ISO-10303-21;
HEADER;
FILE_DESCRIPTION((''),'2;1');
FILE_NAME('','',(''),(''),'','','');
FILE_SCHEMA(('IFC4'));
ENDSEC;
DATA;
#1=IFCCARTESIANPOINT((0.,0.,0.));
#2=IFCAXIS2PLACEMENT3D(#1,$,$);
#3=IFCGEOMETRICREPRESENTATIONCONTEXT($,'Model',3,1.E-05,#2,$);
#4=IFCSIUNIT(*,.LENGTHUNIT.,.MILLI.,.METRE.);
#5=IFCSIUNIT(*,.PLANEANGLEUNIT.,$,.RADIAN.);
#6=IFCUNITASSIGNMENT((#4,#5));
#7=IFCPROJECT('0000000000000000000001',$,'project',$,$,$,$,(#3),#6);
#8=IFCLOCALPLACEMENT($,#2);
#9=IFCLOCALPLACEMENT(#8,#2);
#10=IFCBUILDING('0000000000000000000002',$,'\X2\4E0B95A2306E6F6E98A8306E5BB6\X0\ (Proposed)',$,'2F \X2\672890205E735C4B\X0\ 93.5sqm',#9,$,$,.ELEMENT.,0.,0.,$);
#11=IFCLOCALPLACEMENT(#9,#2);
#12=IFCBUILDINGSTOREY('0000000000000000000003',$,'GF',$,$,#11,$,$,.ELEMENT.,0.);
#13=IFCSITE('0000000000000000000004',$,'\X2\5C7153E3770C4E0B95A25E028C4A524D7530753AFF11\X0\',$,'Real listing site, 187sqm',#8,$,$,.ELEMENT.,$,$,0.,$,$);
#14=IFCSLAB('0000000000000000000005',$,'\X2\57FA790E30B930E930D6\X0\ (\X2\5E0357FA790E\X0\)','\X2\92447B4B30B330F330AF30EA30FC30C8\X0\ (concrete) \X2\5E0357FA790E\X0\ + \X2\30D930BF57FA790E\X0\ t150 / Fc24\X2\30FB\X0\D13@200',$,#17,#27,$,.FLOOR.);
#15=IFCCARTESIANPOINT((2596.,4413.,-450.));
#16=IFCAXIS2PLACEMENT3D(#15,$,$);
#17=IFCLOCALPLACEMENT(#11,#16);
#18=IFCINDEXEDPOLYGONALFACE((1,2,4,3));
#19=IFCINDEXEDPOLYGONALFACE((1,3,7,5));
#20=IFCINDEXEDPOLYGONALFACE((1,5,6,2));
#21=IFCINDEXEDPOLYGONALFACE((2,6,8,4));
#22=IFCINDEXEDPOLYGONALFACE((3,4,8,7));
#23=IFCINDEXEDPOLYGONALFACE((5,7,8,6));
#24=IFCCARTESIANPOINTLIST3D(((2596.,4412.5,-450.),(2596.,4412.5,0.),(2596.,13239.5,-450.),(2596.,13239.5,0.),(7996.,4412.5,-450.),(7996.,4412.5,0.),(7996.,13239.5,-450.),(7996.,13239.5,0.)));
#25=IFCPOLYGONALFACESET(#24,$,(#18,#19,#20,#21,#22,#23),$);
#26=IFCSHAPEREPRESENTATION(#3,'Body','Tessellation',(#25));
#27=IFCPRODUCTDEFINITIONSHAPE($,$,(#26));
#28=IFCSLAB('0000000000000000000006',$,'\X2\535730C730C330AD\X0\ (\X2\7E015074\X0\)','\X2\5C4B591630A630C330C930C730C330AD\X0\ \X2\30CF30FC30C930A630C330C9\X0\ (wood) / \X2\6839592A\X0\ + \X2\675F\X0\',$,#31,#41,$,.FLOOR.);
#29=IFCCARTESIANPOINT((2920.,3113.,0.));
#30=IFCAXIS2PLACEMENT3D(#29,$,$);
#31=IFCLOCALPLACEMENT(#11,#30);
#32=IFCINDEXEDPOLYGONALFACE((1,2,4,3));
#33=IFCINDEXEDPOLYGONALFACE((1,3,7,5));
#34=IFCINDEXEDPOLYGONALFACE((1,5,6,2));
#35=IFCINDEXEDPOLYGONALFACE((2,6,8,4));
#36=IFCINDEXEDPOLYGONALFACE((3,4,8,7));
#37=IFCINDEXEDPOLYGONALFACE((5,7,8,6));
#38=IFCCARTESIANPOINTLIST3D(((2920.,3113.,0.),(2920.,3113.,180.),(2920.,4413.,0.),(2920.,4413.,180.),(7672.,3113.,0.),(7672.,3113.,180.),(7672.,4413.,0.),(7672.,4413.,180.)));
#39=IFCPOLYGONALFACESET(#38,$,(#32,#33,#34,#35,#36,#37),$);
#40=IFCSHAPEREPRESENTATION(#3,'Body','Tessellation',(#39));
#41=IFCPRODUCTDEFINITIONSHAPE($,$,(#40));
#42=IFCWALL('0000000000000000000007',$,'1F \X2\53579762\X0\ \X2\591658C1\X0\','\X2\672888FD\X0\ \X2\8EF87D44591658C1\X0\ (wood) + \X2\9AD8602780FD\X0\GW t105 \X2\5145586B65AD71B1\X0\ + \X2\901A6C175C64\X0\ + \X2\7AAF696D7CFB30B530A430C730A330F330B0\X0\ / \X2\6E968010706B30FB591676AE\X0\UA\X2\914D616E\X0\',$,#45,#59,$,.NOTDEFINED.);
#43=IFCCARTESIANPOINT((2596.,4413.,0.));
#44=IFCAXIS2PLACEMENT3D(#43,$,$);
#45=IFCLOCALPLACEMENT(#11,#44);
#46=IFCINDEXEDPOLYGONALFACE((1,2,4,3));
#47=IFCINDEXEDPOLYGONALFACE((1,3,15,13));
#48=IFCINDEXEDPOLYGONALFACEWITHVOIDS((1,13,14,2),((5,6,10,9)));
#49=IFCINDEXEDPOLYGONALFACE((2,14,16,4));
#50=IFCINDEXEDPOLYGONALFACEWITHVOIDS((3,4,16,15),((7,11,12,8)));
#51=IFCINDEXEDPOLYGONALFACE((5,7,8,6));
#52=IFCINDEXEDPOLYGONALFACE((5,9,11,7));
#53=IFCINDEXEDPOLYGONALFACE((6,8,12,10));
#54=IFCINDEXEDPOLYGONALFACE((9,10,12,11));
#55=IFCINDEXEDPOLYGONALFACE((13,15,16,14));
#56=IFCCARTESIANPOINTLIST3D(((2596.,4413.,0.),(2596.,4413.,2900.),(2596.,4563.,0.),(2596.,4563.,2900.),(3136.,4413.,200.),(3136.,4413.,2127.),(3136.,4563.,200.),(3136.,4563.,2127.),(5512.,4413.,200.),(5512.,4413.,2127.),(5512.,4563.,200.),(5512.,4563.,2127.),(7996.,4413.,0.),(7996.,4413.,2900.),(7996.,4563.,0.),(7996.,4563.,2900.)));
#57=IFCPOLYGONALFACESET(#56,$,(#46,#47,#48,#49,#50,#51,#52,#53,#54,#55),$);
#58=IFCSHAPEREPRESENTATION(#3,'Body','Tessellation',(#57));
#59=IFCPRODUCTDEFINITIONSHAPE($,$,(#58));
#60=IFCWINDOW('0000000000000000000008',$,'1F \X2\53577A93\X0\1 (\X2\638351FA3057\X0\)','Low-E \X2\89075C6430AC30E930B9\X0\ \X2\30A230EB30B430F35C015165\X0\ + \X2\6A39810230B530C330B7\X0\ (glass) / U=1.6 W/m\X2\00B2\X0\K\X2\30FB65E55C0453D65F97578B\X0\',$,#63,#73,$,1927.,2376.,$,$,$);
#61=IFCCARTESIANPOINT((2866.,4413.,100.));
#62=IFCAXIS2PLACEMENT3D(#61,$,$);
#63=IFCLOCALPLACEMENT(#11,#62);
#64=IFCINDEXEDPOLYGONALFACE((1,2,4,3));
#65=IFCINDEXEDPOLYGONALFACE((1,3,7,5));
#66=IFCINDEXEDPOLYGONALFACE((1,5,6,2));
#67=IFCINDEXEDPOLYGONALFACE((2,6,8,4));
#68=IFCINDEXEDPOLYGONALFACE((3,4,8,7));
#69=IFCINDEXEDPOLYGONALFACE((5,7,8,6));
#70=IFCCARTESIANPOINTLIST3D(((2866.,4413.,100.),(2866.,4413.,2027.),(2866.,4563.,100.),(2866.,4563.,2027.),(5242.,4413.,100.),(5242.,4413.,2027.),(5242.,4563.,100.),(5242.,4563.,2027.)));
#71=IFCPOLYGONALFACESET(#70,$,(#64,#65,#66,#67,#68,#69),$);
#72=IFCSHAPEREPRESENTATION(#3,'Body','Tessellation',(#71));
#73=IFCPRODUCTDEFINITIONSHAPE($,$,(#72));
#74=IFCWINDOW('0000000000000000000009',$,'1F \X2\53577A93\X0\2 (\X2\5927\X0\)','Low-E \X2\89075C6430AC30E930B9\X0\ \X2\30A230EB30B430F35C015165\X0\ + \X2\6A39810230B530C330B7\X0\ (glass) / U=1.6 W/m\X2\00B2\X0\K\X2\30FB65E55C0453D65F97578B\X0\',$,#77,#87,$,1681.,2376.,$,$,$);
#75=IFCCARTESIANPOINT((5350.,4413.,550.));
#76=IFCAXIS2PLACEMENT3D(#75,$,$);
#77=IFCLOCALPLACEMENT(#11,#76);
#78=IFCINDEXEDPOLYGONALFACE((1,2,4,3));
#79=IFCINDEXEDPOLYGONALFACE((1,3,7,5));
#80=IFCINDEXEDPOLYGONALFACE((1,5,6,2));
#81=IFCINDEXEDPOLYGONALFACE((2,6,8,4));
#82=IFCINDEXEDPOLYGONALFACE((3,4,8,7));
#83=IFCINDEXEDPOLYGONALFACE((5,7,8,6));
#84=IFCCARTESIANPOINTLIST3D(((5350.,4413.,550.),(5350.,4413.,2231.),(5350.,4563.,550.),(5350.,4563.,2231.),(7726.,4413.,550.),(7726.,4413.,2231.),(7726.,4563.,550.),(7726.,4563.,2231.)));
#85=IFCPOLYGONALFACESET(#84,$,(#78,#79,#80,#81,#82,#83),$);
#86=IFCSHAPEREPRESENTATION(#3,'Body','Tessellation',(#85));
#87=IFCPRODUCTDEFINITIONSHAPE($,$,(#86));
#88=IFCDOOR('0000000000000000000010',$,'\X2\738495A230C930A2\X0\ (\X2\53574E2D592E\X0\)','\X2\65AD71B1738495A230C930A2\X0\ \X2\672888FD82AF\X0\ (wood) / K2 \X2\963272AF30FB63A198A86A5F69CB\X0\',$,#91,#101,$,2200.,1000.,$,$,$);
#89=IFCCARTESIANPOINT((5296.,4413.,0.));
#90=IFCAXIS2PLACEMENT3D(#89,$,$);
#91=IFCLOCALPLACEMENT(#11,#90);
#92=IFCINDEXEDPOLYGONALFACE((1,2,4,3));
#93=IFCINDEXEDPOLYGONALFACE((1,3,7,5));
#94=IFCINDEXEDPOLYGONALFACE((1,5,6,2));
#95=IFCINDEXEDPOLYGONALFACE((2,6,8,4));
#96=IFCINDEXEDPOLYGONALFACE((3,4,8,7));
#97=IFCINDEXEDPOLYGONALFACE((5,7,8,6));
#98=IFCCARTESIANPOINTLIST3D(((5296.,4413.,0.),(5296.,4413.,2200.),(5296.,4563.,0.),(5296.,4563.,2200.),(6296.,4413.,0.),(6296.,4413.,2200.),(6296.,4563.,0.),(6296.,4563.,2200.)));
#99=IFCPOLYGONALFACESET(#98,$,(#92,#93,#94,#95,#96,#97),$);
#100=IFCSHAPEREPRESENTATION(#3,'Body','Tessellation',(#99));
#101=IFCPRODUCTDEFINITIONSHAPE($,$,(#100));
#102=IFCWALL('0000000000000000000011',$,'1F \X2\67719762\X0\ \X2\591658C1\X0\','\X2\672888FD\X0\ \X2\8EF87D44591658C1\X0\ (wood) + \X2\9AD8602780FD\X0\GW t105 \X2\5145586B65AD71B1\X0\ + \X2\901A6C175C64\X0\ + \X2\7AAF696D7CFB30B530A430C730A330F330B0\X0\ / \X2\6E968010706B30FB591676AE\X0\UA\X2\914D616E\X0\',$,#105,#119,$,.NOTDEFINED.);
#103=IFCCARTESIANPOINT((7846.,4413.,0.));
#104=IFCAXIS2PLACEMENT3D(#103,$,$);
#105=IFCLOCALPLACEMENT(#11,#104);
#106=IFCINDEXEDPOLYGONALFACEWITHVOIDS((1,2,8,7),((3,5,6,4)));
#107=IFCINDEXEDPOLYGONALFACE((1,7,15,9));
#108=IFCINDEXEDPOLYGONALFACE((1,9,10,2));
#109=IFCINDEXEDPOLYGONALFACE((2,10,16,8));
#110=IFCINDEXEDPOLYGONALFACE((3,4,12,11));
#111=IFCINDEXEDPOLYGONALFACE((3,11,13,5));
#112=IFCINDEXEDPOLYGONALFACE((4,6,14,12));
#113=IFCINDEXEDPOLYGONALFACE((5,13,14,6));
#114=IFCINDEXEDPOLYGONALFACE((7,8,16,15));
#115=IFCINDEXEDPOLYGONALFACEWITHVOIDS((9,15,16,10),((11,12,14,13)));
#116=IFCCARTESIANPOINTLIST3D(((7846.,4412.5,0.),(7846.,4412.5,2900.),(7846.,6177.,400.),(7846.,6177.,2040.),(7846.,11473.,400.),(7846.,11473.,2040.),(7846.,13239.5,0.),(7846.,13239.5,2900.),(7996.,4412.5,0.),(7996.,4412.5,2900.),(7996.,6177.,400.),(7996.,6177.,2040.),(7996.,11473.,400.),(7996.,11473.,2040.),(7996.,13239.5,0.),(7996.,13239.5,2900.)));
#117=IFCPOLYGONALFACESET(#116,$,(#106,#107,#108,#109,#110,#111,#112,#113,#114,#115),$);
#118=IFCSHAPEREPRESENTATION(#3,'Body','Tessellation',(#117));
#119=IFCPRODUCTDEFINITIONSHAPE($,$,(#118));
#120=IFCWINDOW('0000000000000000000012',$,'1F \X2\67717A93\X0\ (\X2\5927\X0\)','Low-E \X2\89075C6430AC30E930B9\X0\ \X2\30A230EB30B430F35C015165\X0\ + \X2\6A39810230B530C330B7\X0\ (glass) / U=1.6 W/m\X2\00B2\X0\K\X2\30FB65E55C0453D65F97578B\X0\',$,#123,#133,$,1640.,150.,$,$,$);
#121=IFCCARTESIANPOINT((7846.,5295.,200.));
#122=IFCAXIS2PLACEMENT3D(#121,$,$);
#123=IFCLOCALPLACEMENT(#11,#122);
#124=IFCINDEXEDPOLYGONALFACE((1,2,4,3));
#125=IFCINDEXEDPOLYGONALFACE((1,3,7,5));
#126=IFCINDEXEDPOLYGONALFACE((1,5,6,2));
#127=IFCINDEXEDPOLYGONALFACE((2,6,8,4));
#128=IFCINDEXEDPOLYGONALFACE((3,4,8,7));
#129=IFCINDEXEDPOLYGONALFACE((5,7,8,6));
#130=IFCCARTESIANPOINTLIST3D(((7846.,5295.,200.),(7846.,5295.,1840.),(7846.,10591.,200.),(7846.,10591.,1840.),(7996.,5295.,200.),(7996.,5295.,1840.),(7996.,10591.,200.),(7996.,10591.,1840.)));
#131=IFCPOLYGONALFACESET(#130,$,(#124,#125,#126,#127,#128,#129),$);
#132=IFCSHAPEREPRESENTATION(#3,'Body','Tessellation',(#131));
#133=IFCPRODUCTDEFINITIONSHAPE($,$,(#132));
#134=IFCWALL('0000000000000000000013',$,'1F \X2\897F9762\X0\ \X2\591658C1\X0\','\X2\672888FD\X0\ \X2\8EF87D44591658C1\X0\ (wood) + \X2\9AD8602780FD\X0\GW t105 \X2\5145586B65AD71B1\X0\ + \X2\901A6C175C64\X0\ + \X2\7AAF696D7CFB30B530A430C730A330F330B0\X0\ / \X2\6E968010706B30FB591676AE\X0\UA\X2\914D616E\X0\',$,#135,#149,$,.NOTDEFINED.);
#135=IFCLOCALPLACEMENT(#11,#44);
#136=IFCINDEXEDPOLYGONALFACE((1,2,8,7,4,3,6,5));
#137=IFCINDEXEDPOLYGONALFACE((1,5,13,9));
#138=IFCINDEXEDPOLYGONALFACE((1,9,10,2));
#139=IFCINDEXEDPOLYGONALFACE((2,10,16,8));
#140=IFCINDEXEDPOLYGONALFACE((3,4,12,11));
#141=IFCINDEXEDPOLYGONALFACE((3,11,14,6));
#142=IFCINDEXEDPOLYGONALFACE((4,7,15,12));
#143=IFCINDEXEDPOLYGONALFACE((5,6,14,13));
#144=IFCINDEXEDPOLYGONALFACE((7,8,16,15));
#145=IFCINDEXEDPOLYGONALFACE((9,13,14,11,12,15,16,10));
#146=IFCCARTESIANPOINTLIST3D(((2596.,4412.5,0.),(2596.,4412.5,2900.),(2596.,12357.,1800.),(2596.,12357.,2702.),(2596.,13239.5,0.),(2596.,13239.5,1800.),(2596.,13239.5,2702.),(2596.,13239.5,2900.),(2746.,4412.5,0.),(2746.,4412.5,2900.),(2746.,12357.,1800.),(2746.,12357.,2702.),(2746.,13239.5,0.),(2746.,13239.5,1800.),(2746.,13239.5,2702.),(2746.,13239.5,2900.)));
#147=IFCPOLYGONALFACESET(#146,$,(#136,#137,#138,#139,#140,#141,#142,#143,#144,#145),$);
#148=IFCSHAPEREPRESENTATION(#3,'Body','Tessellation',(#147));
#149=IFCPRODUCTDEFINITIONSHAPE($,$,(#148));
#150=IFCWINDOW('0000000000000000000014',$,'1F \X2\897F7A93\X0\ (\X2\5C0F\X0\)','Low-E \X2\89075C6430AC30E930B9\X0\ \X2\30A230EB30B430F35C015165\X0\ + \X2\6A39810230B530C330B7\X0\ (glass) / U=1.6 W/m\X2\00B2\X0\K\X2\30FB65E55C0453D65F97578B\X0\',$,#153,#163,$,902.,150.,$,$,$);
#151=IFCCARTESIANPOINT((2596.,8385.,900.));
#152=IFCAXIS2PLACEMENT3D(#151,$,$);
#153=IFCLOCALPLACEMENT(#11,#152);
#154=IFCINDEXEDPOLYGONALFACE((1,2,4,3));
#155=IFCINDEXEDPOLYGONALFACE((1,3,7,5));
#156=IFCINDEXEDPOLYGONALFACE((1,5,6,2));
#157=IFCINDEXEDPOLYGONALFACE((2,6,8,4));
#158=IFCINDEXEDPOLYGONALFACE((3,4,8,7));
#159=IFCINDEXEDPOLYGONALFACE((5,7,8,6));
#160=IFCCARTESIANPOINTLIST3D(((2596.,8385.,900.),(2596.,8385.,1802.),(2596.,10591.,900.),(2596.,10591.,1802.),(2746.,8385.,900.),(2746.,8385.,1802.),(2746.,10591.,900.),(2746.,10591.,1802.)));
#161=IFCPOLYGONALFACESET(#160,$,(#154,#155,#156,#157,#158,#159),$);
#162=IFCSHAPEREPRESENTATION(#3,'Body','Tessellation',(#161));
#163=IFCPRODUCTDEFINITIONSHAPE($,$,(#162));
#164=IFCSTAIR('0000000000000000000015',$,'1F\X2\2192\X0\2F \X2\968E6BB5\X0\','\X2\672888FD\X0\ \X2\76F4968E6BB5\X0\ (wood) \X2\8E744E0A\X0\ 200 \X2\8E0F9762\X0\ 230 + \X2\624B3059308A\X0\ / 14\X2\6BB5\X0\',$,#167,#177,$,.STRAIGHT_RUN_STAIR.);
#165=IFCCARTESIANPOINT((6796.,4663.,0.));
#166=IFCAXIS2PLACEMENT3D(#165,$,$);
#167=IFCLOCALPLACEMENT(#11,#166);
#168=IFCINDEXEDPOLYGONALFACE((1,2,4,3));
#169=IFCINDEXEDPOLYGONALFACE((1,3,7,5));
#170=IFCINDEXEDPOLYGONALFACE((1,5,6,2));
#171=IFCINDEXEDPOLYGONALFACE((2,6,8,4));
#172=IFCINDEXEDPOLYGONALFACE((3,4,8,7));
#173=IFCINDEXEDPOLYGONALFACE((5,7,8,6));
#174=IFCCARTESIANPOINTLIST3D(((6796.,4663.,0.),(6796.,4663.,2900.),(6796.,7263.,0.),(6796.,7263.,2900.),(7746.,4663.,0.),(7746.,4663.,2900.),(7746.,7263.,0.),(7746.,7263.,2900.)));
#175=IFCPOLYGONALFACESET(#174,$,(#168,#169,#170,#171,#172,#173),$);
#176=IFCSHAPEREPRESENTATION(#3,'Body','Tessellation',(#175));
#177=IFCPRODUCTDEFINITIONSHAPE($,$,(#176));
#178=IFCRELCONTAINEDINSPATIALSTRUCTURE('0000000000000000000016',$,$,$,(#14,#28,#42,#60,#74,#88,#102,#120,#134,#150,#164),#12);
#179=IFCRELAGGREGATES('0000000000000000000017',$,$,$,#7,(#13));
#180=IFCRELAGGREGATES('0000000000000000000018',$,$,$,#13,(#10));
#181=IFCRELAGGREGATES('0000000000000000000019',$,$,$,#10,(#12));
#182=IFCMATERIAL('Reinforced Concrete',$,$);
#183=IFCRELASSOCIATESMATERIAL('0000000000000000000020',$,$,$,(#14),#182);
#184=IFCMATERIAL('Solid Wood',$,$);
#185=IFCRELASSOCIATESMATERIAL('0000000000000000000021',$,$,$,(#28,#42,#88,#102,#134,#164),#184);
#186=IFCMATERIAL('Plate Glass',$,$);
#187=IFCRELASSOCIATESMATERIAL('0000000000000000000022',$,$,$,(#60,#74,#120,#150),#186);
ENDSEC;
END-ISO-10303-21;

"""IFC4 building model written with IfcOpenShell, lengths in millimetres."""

from ifc_helpers import new_model, si_unit, frame, frame_2d, origin, place, context, project, spatial, rectangle, extrude, material, element, fill, save


model = new_model("IFC4")

# Units and contexts
model_context = context("Model", 3, precision=1e-05, world=origin())
ifc_project = project(units=[si_unit("LENGTHUNIT", "METRE", prefix="MILLI"), si_unit("PLANEANGLEUNIT", "RADIAN")], contexts=[model_context])

# Site, building, storey
site_placement = place(None, origin())
site = spatial("IfcSite", under=ifc_project, at=site_placement, Name="山口県下関市豊前田町１", ObjectType="Real listing site, 187sqm", CompositionType="ELEMENT", RefElevation=0.0)
building_placement = place(site_placement, origin())
building = spatial("IfcBuilding", under=site, at=building_placement, Name="下関の潮風の家 (Proposed)", ObjectType="2F 木造平屋 93.5sqm", CompositionType="ELEMENT", ElevationOfRefHeight=0.0, ElevationOfTerrain=0.0)
storey_placement = place(building_placement, origin())
storey = spatial("IfcBuildingStorey", under=building, at=storey_placement, Name="GF", CompositionType="ELEMENT", Elevation=0.0)

# Slabs
ifc_material_1 = material(Name="Reinforced Concrete")
slab_1_placement = place(storey_placement, frame((2596.0, 4413.0, -450.0)))
element("IfcSlab", 1, at=slab_1_placement, inside=storey, material=ifc_material_1, Name="基礎スラブ (布基礎)", Description="鉄筋コンクリート (concrete) 布基礎 + ベタ基礎 t150 / Fc24・D13@200", PredefinedType="FLOOR", context=model_context, shape_type="SweptSolid", body=[
    extrude(rectangle(XDim=5400.0, YDim=8827.0, at=frame_2d((2700.0, 4413.0))), frame((2596.0, 4413.0, -450.0)), (0.0, 0.0, 1.0), 450.0),
])
ifc_material_2 = material(Name="Solid Wood")
slab_2_placement = place(storey_placement, frame((2920.0, 3113.0, 0.0)))
element("IfcSlab", 2, at=slab_2_placement, inside=storey, material=ifc_material_2, Name="南デッキ (縁側)", Description="屋外ウッドデッキ ハードウッド (wood) / 根太 + 束", PredefinedType="FLOOR", context=model_context, shape_type="SweptSolid", body=[
    extrude(rectangle(XDim=4752.0, YDim=1300.0, at=frame_2d((2376.0, 650.0))), frame((2920.0, 3113.0, 0.0)), (0.0, 0.0, 1.0), 180.0),
])

# Wall, openings, windows, door
wall_1_placement = place(storey_placement, frame((2596.0, 4413.0, 0.0)))
wall_1 = element("IfcWall", 3, at=wall_1_placement, inside=storey, material=ifc_material_2, Name="1F 南面 外壁", Description="木製 軸組外壁 (wood) + 高性能GW t105 充填断熱 + 通気層 + 窯業系サイディング / 準耐火・外皮UA配慮", PredefinedType="NOTDEFINED", context=model_context, shape_type="SweptSolid", body=[
    extrude(rectangle(XDim=5400.0, YDim=150.0, at=frame_2d((2700.0, 75.0))), frame((2596.0, 4413.0, 0.0)), (0.0, 0.0, 1.0), 2900.0),
])
opening_1_placement = place(storey_placement, frame((2866.0, 4413.0, 100.0)))
opening_1 = element("IfcOpeningElement", 4, at=opening_1_placement, cuts=wall_1, PredefinedType="NOTDEFINED", context=model_context, shape_type="SweptSolid", body=[
    extrude(rectangle(XDim=2376.0, YDim=150.0, at=frame_2d((1188.0, 75.0))), frame((2866.0, 4413.0, 100.0)), (0.0, 0.0, 1.0), 1927.0),
])
opening_2_placement = place(storey_placement, frame((5350.0, 4413.0, 550.0)))
opening_2 = element("IfcOpeningElement", 5, at=opening_2_placement, cuts=wall_1, PredefinedType="NOTDEFINED", context=model_context, shape_type="SweptSolid", body=[
    extrude(rectangle(XDim=2376.0, YDim=150.0, at=frame_2d((1188.0, 75.0))), frame((5350.0, 4413.0, 550.0)), (0.0, 0.0, 1.0), 1681.0),
])
opening_3_placement = place(storey_placement, frame((5296.0, 4413.0, 0.0)))
opening_3 = element("IfcOpeningElement", 6, at=opening_3_placement, cuts=wall_1, PredefinedType="NOTDEFINED", context=model_context, shape_type="SweptSolid", body=[
    extrude(rectangle(XDim=1000.0, YDim=150.0, at=frame_2d((500.0, 75.0))), frame((5296.0, 4413.0, 0.0)), (0.0, 0.0, 1.0), 2200.0),
])
ifc_material_3 = material(Name="Plate Glass")
window_1_placement = place(storey_placement, frame((2866.0, 4413.0, 100.0)))
window_1 = element("IfcWindow", 7, at=window_1_placement, inside=storey, material=ifc_material_3, Name="1F 南窓1 (掃出し)", Description="Low-E 複層ガラス アルゴン封入 + 樹脂サッシ (glass) / U=1.6 W/m²K・日射取得型", OverallHeight=1927.0, OverallWidth=2376.0, context=model_context, shape_type="SweptSolid", body=[
    extrude(rectangle(XDim=2376.0, YDim=150.0, at=frame_2d((1188.0, 75.0))), frame((2866.0, 4413.0, 100.0)), (0.0, 0.0, 1.0), 1927.0),
])
fill(opening_1, window_1)
window_2_placement = place(storey_placement, frame((5350.0, 4413.0, 550.0)))
window_2 = element("IfcWindow", 8, at=window_2_placement, inside=storey, material=ifc_material_3, Name="1F 南窓2 (大)", Description="Low-E 複層ガラス アルゴン封入 + 樹脂サッシ (glass) / U=1.6 W/m²K・日射取得型", OverallHeight=1681.0, OverallWidth=2376.0, context=model_context, shape_type="SweptSolid", body=[
    extrude(rectangle(XDim=2376.0, YDim=150.0, at=frame_2d((1188.0, 75.0))), frame((5350.0, 4413.0, 550.0)), (0.0, 0.0, 1.0), 1681.0),
])
fill(opening_2, window_2)
door_placement = place(storey_placement, frame((5296.0, 4413.0, 0.0)))
door = element("IfcDoor", 9, at=door_placement, inside=storey, material=ifc_material_2, Name="玄関ドア (南中央)", Description="断熱玄関ドア 木製芯 (wood) / K2 防犯・採風機構", OverallHeight=2200.0, OverallWidth=1000.0, context=model_context, shape_type="SweptSolid", body=[
    extrude(rectangle(XDim=1000.0, YDim=150.0, at=frame_2d((500.0, 75.0))), frame((5296.0, 4413.0, 0.0)), (0.0, 0.0, 1.0), 2200.0),
])
fill(opening_3, door)

# Walls, openings, windows
wall_2_placement = place(storey_placement, frame((7846.0, 4413.0, 0.0)))
wall_2 = element("IfcWall", 10, at=wall_2_placement, inside=storey, material=ifc_material_2, Name="1F 東面 外壁", Description="木製 軸組外壁 (wood) + 高性能GW t105 充填断熱 + 通気層 + 窯業系サイディング / 準耐火・外皮UA配慮", PredefinedType="NOTDEFINED", context=model_context, shape_type="SweptSolid", body=[
    extrude(rectangle(XDim=150.0, YDim=8827.0, at=frame_2d((75.0, 4413.0))), frame((7846.0, 4413.0, 0.0)), (0.0, 0.0, 1.0), 2900.0),
])
opening_4_placement = place(storey_placement, frame((7846.0, 5295.0, 200.0)))
opening_4 = element("IfcOpeningElement", 11, at=opening_4_placement, cuts=wall_2, PredefinedType="NOTDEFINED", context=model_context, shape_type="SweptSolid", body=[
    extrude(rectangle(XDim=150.0, YDim=5296.0, at=frame_2d((75.0, 2648.0))), frame((7846.0, 5295.0, 200.0)), (0.0, 0.0, 1.0), 1640.0),
])
window_3_placement = place(storey_placement, frame((7846.0, 5295.0, 200.0)))
window_3 = element("IfcWindow", 12, at=window_3_placement, inside=storey, material=ifc_material_3, Name="1F 東窓 (大)", Description="Low-E 複層ガラス アルゴン封入 + 樹脂サッシ (glass) / U=1.6 W/m²K・日射取得型", OverallHeight=1640.0, OverallWidth=150.0, context=model_context, shape_type="SweptSolid", body=[
    extrude(rectangle(XDim=150.0, YDim=5296.0, at=frame_2d((75.0, 2648.0))), frame((7846.0, 5295.0, 200.0)), (0.0, 0.0, 1.0), 1640.0),
])
fill(opening_4, window_3)
wall_3_placement = place(storey_placement, frame((2596.0, 4413.0, 0.0)))
wall_3 = element("IfcWall", 13, at=wall_3_placement, inside=storey, material=ifc_material_2, Name="1F 西面 外壁", Description="木製 軸組外壁 (wood) + 高性能GW t105 充填断熱 + 通気層 + 窯業系サイディング / 準耐火・外皮UA配慮", PredefinedType="NOTDEFINED", context=model_context, shape_type="SweptSolid", body=[
    extrude(rectangle(XDim=150.0, YDim=8827.0, at=frame_2d((75.0, 4413.0))), frame((2596.0, 4413.0, 0.0)), (0.0, 0.0, 1.0), 2900.0),
])
opening_5_placement = place(storey_placement, frame((2596.0, 8385.0, 900.0)))
opening_5 = element("IfcOpeningElement", 14, at=opening_5_placement, cuts=wall_3, PredefinedType="NOTDEFINED", context=model_context, shape_type="SweptSolid", body=[
    extrude(rectangle(XDim=150.0, YDim=2206.0, at=frame_2d((75.0, 1103.0))), frame((2596.0, 8385.0, 900.0)), (0.0, 0.0, 1.0), 902.0),
])
window_4_placement = place(storey_placement, frame((2596.0, 8385.0, 900.0)))
window_4 = element("IfcWindow", 15, at=window_4_placement, inside=storey, material=ifc_material_3, Name="1F 西窓 (小)", Description="Low-E 複層ガラス アルゴン封入 + 樹脂サッシ (glass) / U=1.6 W/m²K・日射取得型", OverallHeight=902.0, OverallWidth=150.0, context=model_context, shape_type="SweptSolid", body=[
    extrude(rectangle(XDim=150.0, YDim=2206.0, at=frame_2d((75.0, 1103.0))), frame((2596.0, 8385.0, 900.0)), (0.0, 0.0, 1.0), 902.0),
])
fill(opening_5, window_4)

# Stair
stair_placement = place(storey_placement, frame((6796.0, 4663.0, 0.0)))
element("IfcStair", 16, at=stair_placement, inside=storey, material=ifc_material_2, Name="1F→2F 階段", Description="木製 直階段 (wood) 蹴上 200 踏面 230 + 手すり / 14段", PredefinedType="STRAIGHT_RUN_STAIR", context=model_context, shape_type="SweptSolid", body=[
    extrude(rectangle(XDim=950.0, YDim=2600.0, at=frame_2d((475.0, 1300.0))), frame((6796.0, 4663.0, 0.0)), (0.0, 0.0, 1.0), 2900.0),
])

save(model, "model.ifc")
